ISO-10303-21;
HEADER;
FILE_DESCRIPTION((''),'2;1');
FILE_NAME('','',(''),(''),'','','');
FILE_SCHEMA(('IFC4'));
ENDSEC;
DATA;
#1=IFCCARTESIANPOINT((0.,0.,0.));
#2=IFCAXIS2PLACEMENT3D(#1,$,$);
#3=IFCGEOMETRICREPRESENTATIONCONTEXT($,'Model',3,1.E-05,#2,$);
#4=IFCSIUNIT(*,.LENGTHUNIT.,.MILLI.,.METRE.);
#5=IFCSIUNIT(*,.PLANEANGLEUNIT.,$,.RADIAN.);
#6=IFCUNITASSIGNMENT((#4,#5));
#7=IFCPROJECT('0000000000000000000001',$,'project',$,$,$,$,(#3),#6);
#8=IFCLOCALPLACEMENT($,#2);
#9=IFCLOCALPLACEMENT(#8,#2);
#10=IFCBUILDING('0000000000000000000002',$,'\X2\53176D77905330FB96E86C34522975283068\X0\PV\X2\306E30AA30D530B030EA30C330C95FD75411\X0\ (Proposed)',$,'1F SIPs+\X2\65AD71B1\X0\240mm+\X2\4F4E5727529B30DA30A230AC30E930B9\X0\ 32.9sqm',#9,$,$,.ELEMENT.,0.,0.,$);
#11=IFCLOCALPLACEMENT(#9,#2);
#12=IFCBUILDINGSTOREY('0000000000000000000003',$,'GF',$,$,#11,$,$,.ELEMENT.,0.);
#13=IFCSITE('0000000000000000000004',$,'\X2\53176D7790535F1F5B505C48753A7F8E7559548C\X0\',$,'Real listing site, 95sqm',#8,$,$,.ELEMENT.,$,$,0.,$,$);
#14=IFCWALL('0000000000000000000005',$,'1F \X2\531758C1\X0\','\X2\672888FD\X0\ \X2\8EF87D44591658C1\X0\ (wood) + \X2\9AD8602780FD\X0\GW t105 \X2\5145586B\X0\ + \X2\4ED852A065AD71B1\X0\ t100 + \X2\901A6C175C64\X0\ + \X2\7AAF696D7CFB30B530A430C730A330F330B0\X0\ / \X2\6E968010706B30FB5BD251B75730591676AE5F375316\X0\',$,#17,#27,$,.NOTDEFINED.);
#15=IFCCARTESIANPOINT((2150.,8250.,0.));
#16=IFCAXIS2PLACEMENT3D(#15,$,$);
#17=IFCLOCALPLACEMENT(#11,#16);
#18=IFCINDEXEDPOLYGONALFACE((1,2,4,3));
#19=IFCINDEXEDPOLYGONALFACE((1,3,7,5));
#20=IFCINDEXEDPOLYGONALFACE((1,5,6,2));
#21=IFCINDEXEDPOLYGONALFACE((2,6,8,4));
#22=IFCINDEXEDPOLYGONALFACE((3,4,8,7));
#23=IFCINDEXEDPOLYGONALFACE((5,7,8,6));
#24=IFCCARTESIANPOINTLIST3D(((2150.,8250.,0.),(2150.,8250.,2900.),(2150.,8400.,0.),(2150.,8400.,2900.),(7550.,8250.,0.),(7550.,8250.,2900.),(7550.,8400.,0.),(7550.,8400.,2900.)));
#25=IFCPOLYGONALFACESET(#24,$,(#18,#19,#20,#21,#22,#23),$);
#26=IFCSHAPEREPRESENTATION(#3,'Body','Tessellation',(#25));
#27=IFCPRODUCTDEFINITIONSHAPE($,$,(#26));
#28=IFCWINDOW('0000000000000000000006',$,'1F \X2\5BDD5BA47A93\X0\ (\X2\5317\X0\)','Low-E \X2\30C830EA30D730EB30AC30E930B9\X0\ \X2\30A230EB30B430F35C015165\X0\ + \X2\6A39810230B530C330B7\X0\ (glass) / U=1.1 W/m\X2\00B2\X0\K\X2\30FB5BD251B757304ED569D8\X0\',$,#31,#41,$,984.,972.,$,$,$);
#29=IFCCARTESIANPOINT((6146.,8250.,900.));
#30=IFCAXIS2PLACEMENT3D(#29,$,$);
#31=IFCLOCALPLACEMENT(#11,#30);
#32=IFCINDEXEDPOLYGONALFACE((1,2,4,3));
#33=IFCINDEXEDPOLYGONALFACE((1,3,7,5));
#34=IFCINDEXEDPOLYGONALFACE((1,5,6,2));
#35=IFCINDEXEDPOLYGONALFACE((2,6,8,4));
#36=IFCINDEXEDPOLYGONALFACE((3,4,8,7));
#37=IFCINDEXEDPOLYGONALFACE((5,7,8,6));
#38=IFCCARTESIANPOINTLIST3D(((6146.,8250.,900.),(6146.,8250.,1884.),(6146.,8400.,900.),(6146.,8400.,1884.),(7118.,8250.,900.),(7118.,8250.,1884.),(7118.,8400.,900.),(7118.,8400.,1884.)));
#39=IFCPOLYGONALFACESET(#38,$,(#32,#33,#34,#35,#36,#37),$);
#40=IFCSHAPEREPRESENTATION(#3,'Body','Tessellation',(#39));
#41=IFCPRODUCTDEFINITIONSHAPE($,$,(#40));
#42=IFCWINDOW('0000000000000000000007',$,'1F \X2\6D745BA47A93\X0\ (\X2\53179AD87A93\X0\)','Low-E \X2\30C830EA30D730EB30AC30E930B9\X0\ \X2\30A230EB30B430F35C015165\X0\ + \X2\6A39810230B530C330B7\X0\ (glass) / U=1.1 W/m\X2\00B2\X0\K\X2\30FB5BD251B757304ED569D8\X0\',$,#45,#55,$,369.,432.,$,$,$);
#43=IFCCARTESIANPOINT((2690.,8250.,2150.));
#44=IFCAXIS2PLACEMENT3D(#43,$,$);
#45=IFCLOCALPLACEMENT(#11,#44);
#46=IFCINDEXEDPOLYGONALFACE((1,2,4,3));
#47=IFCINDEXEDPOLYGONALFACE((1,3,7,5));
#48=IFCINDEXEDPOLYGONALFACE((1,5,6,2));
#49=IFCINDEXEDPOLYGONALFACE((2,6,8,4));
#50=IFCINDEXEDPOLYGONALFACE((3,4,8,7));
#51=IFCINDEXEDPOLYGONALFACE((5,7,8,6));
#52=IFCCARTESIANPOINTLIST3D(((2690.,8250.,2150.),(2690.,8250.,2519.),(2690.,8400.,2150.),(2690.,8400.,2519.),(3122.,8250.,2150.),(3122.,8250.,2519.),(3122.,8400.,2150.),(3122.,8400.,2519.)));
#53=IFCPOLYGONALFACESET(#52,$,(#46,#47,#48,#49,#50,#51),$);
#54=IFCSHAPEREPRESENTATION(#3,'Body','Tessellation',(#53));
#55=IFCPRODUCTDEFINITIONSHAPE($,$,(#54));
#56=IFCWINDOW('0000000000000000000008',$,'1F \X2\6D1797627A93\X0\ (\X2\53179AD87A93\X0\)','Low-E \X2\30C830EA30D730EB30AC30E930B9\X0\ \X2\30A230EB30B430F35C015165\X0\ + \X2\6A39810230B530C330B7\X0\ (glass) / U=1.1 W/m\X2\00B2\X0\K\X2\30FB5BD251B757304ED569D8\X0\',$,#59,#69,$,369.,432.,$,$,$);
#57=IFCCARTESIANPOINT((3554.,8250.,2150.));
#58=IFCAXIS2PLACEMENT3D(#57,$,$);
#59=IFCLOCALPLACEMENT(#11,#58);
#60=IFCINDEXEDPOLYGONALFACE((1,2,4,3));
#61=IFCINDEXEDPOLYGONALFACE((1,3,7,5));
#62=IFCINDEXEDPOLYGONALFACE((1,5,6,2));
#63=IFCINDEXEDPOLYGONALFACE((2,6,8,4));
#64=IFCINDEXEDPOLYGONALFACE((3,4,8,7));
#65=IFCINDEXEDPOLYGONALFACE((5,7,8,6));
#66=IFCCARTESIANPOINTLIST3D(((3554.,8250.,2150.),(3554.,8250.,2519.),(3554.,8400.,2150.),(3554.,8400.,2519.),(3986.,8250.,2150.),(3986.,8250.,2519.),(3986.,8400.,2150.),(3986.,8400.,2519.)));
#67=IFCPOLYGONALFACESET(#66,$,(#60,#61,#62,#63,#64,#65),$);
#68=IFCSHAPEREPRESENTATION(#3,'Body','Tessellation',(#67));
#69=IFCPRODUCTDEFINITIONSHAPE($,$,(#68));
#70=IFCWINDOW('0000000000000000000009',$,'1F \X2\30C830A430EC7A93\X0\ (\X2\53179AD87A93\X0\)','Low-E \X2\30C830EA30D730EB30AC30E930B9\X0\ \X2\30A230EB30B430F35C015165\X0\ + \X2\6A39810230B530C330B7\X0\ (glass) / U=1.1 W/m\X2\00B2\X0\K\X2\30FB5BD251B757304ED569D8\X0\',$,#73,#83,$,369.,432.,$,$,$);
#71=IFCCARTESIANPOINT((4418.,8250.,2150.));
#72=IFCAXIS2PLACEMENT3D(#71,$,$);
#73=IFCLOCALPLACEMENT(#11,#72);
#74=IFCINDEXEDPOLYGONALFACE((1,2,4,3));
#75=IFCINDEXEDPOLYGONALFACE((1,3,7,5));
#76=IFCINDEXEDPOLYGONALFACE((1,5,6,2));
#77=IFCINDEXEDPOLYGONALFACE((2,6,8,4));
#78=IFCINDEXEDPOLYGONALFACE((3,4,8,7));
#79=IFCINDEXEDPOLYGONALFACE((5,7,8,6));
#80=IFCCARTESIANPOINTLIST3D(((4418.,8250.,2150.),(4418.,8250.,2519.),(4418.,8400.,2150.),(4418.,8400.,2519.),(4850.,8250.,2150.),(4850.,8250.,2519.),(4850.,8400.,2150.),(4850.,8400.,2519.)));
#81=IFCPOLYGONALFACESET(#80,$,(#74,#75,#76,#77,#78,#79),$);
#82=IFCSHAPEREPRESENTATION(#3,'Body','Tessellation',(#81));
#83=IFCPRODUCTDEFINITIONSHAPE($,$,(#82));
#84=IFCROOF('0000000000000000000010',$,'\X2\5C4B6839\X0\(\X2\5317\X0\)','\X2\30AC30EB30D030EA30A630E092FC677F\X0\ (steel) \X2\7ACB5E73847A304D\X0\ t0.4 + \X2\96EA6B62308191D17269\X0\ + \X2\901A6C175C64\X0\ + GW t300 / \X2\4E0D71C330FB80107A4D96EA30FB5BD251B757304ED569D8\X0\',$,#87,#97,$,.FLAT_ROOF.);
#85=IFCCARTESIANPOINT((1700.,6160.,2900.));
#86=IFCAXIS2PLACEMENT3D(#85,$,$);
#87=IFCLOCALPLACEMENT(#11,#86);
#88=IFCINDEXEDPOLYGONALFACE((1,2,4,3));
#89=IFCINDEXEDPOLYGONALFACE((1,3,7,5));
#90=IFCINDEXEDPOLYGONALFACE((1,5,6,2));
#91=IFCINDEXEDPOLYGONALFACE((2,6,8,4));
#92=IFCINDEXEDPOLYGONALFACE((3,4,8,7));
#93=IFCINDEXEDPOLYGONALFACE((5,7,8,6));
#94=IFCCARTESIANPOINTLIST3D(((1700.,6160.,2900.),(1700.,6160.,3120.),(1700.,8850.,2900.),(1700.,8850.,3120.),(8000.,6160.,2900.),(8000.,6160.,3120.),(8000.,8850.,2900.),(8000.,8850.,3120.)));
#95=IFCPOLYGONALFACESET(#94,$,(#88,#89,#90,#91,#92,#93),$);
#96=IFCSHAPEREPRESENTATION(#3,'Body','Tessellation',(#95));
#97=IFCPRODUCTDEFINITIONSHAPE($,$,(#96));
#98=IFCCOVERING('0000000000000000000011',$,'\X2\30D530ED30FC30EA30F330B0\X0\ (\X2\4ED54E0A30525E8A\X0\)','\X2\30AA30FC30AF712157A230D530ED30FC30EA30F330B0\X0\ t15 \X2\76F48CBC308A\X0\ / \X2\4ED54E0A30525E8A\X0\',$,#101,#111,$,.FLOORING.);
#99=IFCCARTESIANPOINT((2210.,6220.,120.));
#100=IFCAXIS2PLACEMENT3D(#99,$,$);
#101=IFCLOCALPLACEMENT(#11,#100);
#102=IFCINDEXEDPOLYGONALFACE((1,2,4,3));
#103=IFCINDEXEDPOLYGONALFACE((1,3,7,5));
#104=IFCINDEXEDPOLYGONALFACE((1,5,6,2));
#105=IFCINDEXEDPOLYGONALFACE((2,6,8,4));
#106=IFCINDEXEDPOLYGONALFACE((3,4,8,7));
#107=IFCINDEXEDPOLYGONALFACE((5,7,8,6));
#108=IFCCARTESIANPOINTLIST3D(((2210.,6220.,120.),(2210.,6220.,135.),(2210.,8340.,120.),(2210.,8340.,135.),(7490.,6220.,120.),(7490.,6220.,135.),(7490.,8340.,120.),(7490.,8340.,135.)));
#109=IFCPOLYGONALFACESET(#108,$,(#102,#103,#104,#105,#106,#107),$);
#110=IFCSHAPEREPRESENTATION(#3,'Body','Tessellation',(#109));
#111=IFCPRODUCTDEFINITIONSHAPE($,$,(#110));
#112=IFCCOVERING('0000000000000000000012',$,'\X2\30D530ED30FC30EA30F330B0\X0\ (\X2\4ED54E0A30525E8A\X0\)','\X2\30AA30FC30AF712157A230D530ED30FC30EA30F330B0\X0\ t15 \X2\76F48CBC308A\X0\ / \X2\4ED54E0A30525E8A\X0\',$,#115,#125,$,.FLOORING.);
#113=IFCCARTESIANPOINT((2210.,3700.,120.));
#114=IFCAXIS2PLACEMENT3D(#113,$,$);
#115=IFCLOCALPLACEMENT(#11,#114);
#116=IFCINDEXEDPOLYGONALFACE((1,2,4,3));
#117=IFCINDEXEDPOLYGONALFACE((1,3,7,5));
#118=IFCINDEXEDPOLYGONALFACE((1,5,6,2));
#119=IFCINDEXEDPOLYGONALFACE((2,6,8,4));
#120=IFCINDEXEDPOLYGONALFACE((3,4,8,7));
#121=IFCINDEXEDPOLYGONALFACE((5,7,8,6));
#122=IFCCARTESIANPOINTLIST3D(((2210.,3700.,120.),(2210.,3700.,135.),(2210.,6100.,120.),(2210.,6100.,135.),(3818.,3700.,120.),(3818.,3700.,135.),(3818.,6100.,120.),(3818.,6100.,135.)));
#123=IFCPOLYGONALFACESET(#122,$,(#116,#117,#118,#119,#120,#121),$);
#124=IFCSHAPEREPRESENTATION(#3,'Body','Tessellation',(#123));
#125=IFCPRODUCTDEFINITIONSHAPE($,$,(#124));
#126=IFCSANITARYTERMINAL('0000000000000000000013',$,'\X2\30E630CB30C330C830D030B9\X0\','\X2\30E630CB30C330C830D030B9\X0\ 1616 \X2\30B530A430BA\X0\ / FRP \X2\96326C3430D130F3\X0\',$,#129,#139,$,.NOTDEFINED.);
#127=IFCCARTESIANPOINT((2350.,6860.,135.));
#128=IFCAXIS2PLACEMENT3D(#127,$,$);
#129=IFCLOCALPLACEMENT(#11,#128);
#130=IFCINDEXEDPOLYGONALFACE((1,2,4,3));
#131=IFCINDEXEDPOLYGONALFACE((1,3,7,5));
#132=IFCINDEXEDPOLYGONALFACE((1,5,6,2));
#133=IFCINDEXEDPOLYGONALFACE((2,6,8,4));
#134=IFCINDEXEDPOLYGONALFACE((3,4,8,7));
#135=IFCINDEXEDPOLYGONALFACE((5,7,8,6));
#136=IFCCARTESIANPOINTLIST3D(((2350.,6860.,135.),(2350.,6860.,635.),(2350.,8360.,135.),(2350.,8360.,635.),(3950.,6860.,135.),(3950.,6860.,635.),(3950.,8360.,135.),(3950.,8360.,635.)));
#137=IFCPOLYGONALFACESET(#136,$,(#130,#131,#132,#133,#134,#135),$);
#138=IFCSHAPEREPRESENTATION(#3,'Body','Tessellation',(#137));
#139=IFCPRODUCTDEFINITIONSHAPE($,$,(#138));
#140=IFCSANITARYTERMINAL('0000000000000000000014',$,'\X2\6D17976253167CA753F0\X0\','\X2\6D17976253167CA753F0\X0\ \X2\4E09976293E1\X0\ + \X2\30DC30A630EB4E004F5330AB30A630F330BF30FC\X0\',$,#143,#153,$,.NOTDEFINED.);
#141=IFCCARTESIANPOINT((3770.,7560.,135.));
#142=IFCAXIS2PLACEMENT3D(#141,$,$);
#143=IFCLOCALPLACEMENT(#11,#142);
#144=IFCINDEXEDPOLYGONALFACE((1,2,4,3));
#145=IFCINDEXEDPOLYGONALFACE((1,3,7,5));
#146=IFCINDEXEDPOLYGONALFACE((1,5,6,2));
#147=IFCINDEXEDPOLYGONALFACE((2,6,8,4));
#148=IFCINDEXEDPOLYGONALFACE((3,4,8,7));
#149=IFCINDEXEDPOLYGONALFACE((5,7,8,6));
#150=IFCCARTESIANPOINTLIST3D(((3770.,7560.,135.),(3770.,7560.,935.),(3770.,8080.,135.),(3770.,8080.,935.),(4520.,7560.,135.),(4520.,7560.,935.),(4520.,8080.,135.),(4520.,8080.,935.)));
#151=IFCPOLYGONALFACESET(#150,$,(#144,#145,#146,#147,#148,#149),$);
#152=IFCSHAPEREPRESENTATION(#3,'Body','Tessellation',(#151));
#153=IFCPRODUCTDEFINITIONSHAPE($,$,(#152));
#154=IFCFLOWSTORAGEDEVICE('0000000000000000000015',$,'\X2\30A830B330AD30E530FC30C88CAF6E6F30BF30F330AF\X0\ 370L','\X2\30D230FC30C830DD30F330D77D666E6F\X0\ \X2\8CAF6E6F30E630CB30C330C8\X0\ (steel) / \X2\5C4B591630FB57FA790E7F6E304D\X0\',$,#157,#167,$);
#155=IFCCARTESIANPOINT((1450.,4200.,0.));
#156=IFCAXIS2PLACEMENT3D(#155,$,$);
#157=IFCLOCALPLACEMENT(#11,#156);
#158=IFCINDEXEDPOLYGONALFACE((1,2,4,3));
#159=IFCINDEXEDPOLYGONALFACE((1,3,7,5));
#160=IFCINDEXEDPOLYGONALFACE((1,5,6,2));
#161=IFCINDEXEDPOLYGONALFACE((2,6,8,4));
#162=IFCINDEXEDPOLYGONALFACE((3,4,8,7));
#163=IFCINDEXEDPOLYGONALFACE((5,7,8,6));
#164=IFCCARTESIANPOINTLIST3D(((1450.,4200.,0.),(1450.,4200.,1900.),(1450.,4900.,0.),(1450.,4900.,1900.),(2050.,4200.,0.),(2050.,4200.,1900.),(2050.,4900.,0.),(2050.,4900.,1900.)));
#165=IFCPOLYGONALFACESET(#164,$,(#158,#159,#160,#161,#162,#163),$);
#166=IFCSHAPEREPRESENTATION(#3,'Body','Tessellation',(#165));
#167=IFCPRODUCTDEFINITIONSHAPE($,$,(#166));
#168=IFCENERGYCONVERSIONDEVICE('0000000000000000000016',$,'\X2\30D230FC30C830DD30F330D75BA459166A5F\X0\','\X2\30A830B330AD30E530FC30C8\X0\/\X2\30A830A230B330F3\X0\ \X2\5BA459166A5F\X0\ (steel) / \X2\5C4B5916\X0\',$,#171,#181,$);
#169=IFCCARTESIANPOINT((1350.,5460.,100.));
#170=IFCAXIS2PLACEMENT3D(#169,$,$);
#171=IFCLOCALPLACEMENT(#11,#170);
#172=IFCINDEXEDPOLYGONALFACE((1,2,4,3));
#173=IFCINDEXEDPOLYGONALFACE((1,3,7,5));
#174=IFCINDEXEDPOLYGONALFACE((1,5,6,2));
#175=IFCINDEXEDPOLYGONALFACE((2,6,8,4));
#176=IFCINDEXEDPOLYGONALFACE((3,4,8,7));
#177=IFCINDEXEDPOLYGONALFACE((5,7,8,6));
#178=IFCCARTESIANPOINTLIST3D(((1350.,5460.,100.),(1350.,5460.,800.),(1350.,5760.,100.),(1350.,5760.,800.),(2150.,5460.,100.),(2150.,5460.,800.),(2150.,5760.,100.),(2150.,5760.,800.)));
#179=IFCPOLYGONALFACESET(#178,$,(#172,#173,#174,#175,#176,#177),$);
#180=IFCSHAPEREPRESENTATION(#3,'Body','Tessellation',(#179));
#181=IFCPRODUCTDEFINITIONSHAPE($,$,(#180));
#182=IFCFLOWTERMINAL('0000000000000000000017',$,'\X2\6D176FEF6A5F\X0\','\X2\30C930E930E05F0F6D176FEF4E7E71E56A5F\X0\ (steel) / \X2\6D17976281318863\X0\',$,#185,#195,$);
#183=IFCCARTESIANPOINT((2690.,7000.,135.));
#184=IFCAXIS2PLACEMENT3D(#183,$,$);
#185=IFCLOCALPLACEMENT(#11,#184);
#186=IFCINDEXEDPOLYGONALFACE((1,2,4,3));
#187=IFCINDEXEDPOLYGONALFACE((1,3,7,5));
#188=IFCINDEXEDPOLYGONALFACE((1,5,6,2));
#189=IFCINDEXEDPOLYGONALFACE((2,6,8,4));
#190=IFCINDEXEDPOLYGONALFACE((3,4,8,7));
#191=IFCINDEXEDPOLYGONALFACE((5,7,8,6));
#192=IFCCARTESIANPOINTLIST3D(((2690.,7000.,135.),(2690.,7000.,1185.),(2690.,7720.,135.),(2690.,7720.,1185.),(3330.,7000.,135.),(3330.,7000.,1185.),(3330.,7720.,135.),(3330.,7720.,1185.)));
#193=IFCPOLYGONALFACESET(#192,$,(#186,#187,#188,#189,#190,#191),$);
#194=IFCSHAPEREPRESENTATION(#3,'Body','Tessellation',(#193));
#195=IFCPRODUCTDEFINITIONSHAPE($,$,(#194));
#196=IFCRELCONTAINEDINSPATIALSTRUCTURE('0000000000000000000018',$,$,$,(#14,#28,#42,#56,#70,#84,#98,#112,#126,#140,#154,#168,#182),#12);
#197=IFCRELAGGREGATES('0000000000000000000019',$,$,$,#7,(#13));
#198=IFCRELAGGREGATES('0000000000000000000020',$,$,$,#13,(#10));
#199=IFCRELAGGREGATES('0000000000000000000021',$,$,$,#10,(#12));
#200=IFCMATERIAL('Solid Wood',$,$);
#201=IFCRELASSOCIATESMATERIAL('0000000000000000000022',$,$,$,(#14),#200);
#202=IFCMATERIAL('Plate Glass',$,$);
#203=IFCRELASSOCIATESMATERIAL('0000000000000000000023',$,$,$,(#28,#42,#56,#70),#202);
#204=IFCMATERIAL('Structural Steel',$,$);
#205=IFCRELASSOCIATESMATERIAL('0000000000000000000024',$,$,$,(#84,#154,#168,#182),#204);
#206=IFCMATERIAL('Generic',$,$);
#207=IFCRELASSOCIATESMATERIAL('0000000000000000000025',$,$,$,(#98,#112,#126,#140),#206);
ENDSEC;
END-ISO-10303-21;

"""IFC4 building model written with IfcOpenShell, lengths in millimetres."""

from ifc_helpers import new_model, si_unit, frame, frame_2d, origin, place, context, project, spatial, rectangle, extrude, material, element, fill, save


model = new_model("IFC4")

# Units and contexts
model_context = context("Model", 3, precision=1e-05, world=origin())
ifc_project = project(units=[si_unit("LENGTHUNIT", "METRE", prefix="MILLI"), si_unit("PLANEANGLEUNIT", "RADIAN")], contexts=[model_context])

# Site, building, storey
site_placement = place(None, origin())
site = spatial("IfcSite", under=ifc_project, at=site_placement, Name="北海道弟子屈町美留和", ObjectType="Real listing site, 95sqm", CompositionType="ELEMENT", RefElevation=0.0)
building_placement = place(site_placement, origin())
building = spatial("IfcBuilding", under=site, at=building_placement, Name="北海道・雨水利用とPVのオフグリッド志向 (Proposed)", ObjectType="1F SIPs+断熱240mm+低圧力ペアガラス 32.9sqm", CompositionType="ELEMENT", ElevationOfRefHeight=0.0, ElevationOfTerrain=0.0)
storey_placement = place(building_placement, origin())
storey = spatial("IfcBuildingStorey", under=building, at=storey_placement, Name="GF", CompositionType="ELEMENT", Elevation=0.0)

# Shared definitions
ifc_material_1 = material(Name="Solid Wood")

# Wall, openings, windows
wall_1_placement = place(storey_placement, frame((2150.0, 8250.0, 0.0)))
wall_1 = element("IfcWall", 1, at=wall_1_placement, inside=storey, material=ifc_material_1, Name="1F 北壁", Description="木製 軸組外壁 (wood) + 高性能GW t105 充填 + 付加断熱 t100 + 通気層 + 窯業系サイディング / 準耐火・寒冷地外皮強化", PredefinedType="NOTDEFINED", context=model_context, shape_type="SweptSolid", body=[
    extrude(rectangle(XDim=5400.0, YDim=150.0, at=frame_2d((2700.0, 75.0))), frame((2150.0, 8250.0, 0.0)), (0.0, 0.0, 1.0), 2900.0),
])
opening_1_placement = place(storey_placement, frame((6146.0, 8250.0, 900.0)))
opening_1 = element("IfcOpeningElement", 2, at=opening_1_placement, cuts=wall_1, PredefinedType="NOTDEFINED", context=model_context, shape_type="SweptSolid", body=[
    extrude(rectangle(XDim=972.0, YDim=150.0, at=frame_2d((486.0, 75.0))), frame((6146.0, 8250.0, 900.0)), (0.0, 0.0, 1.0), 984.0),
])
opening_2_placement = place(storey_placement, frame((2690.0, 8250.0, 2150.0)))
opening_2 = element("IfcOpeningElement", 3, at=opening_2_placement, cuts=wall_1, PredefinedType="NOTDEFINED", context=model_context, shape_type="SweptSolid", body=[
    extrude(rectangle(XDim=432.0, YDim=150.0, at=frame_2d((216.0, 75.0))), frame((2690.0, 8250.0, 2150.0)), (0.0, 0.0, 1.0), 369.0),
])
opening_3_placement = place(storey_placement, frame((3554.0, 8250.0, 2150.0)))
opening_3 = element("IfcOpeningElement", 4, at=opening_3_placement, cuts=wall_1, PredefinedType="NOTDEFINED", context=model_context, shape_type="SweptSolid", body=[
    extrude(rectangle(XDim=432.0, YDim=150.0, at=frame_2d((216.0, 75.0))), frame((3554.0, 8250.0, 2150.0)), (0.0, 0.0, 1.0), 369.0),
])
opening_4_placement = place(storey_placement, frame((4418.0, 8250.0, 2150.0)))
opening_4 = element("IfcOpeningElement", 5, at=opening_4_placement, cuts=wall_1, PredefinedType="NOTDEFINED", context=model_context, shape_type="SweptSolid", body=[
    extrude(rectangle(XDim=432.0, YDim=150.0, at=frame_2d((216.0, 75.0))), frame((4418.0, 8250.0, 2150.0)), (0.0, 0.0, 1.0), 369.0),
])
ifc_material_2 = material(Name="Plate Glass")
window_1_placement = place(storey_placement, frame((6146.0, 8250.0, 900.0)))
window_1 = element("IfcWindow", 6, at=window_1_placement, inside=storey, material=ifc_material_2, Name="1F 寝室窓 (北)", Description="Low-E トリプルガラス アルゴン封入 + 樹脂サッシ (glass) / U=1.1 W/m²K・寒冷地仕様", OverallHeight=984.0, OverallWidth=972.0, context=model_context, shape_type="SweptSolid", body=[
    extrude(rectangle(XDim=972.0, YDim=150.0, at=frame_2d((486.0, 75.0))), frame((6146.0, 8250.0, 900.0)), (0.0, 0.0, 1.0), 984.0),
])
fill(opening_1, window_1)
window_2_placement = place(storey_placement, frame((2690.0, 8250.0, 2150.0)))
window_2 = element("IfcWindow", 7, at=window_2_placement, inside=storey, material=ifc_material_2, Name="1F 浴室窓 (北高窓)", Description="Low-E トリプルガラス アルゴン封入 + 樹脂サッシ (glass) / U=1.1 W/m²K・寒冷地仕様", OverallHeight=369.0, OverallWidth=432.0, context=model_context, shape_type="SweptSolid", body=[
    extrude(rectangle(XDim=432.0, YDim=150.0, at=frame_2d((216.0, 75.0))), frame((2690.0, 8250.0, 2150.0)), (0.0, 0.0, 1.0), 369.0),
])
fill(opening_2, window_2)
window_3_placement = place(storey_placement, frame((3554.0, 8250.0, 2150.0)))
window_3 = element("IfcWindow", 8, at=window_3_placement, inside=storey, material=ifc_material_2, Name="1F 洗面窓 (北高窓)", Description="Low-E トリプルガラス アルゴン封入 + 樹脂サッシ (glass) / U=1.1 W/m²K・寒冷地仕様", OverallHeight=369.0, OverallWidth=432.0, context=model_context, shape_type="SweptSolid", body=[
    extrude(rectangle(XDim=432.0, YDim=150.0, at=frame_2d((216.0, 75.0))), frame((3554.0, 8250.0, 2150.0)), (0.0, 0.0, 1.0), 369.0),
])
fill(opening_3, window_3)
window_4_placement = place(storey_placement, frame((4418.0, 8250.0, 2150.0)))
window_4 = element("IfcWindow", 9, at=window_4_placement, inside=storey, material=ifc_material_2, Name="1F トイレ窓 (北高窓)", Description="Low-E トリプルガラス アルゴン封入 + 樹脂サッシ (glass) / U=1.1 W/m²K・寒冷地仕様", OverallHeight=369.0, OverallWidth=432.0, context=model_context, shape_type="SweptSolid", body=[
    extrude(rectangle(XDim=432.0, YDim=150.0, at=frame_2d((216.0, 75.0))), frame((4418.0, 8250.0, 2150.0)), (0.0, 0.0, 1.0), 369.0),
])
fill(opening_4, window_4)

# Roof
ifc_material_3 = material(Name="Structural Steel")
roof_placement = place(storey_placement, frame((1700.0, 6160.0, 2900.0)))
element("IfcRoof", 10, at=roof_placement, inside=storey, material=ifc_material_3, Name="屋根(北)", Description="ガルバリウム鋼板 (steel) 立平葺き t0.4 + 雪止め金物 + 通気層 + GW t300 / 不燃・耐積雪・寒冷地仕様", PredefinedType="FLAT_ROOF", context=model_context, shape_type="SweptSolid", body=[
    extrude(rectangle(XDim=6300.0, YDim=2690.0, at=frame_2d((3150.0, 1345.0))), frame((1700.0, 6160.0, 2900.0)), (0.0, 0.0, 1.0), 220.0),
])

# Coverings
ifc_material_4 = material(Name="Generic")
covering_1_placement = place(storey_placement, frame((2210.0, 6220.0, 120.0)))
element("IfcCovering", 11, at=covering_1_placement, inside=storey, material=ifc_material_4, Name="フローリング (仕上げ床)", Description="オーク無垢フローリング t15 直貼り / 仕上げ床", PredefinedType="FLOORING", context=model_context, shape_type="SweptSolid", body=[
    extrude(rectangle(XDim=5280.0, YDim=2120.0, at=frame_2d((2640.0, 1060.0))), frame((2210.0, 6220.0, 120.0)), (0.0, 0.0, 1.0), 15.0),
])
covering_2_placement = place(storey_placement, frame((2210.0, 3700.0, 120.0)))
element("IfcCovering", 12, at=covering_2_placement, inside=storey, material=ifc_material_4, Name="フローリング (仕上げ床)", Description="オーク無垢フローリング t15 直貼り / 仕上げ床", PredefinedType="FLOORING", context=model_context, shape_type="SweptSolid", body=[
    extrude(rectangle(XDim=1608.0, YDim=2400.0, at=frame_2d((804.0, 1200.0))), frame((2210.0, 3700.0, 120.0)), (0.0, 0.0, 1.0), 15.0),
])

# Sanitary terminals
sanitary_terminal_1_placement = place(storey_placement, frame((2350.0, 6860.0, 135.0)))
element("IfcSanitaryTerminal", 13, at=sanitary_terminal_1_placement, inside=storey, material=ifc_material_4, Name="ユニットバス", Description="ユニットバス 1616 サイズ / FRP 防水パン", PredefinedType="NOTDEFINED", context=model_context, shape_type="SweptSolid", body=[
    extrude(rectangle(XDim=1600.0, YDim=1500.0, at=frame_2d((800.0, 750.0))), frame((2350.0, 6860.0, 135.0)), (0.0, 0.0, 1.0), 500.0),
])
sanitary_terminal_2_placement = place(storey_placement, frame((3770.0, 7560.0, 135.0)))
element("IfcSanitaryTerminal", 14, at=sanitary_terminal_2_placement, inside=storey, material=ifc_material_4, Name="洗面化粧台", Description="洗面化粧台 三面鏡 + ボウル一体カウンター", PredefinedType="NOTDEFINED", context=model_context, shape_type="SweptSolid", body=[
    extrude(rectangle(XDim=750.0, YDim=520.0, at=frame_2d((375.0, 260.0))), frame((3770.0, 7560.0, 135.0)), (0.0, 0.0, 1.0), 800.0),
])

# Flow storage device
flow_storage_device_placement = place(storey_placement, frame((1450.0, 4200.0, 0.0)))
element("IfcFlowStorageDevice", 15, at=flow_storage_device_placement, inside=storey, material=ifc_material_3, Name="エコキュート貯湯タンク 370L", Description="ヒートポンプ給湯 貯湯ユニット (steel) / 屋外・基礎置き", context=model_context, shape_type="SweptSolid", body=[
    extrude(rectangle(XDim=600.0, YDim=700.0, at=frame_2d((300.0, 350.0))), frame((1450.0, 4200.0, 0.0)), (0.0, 0.0, 1.0), 1900.0),
])

# Energy conversion device
energy_conversion_device_placement = place(storey_placement, frame((1350.0, 5460.0, 100.0)))
element("IfcEnergyConversionDevice", 16, at=energy_conversion_device_placement, inside=storey, material=ifc_material_3, Name="ヒートポンプ室外機", Description="エコキュート/エアコン 室外機 (steel) / 屋外", context=model_context, shape_type="SweptSolid", body=[
    extrude(rectangle(XDim=800.0, YDim=300.0, at=frame_2d((400.0, 150.0))), frame((1350.0, 5460.0, 100.0)), (0.0, 0.0, 1.0), 700.0),
])

# Flow terminal
flow_terminal_placement = place(storey_placement, frame((2690.0, 7000.0, 135.0)))
element("IfcFlowTerminal", 17, at=flow_terminal_placement, inside=storey, material=ifc_material_3, Name="洗濯機", Description="ドラム式洗濯乾燥機 (steel) / 洗面脱衣", context=model_context, shape_type="SweptSolid", body=[
    extrude(rectangle(XDim=640.0, YDim=720.0, at=frame_2d((320.0, 360.0))), frame((2690.0, 7000.0, 135.0)), (0.0, 0.0, 1.0), 1050.0),
])

save(model, "model.ifc")
